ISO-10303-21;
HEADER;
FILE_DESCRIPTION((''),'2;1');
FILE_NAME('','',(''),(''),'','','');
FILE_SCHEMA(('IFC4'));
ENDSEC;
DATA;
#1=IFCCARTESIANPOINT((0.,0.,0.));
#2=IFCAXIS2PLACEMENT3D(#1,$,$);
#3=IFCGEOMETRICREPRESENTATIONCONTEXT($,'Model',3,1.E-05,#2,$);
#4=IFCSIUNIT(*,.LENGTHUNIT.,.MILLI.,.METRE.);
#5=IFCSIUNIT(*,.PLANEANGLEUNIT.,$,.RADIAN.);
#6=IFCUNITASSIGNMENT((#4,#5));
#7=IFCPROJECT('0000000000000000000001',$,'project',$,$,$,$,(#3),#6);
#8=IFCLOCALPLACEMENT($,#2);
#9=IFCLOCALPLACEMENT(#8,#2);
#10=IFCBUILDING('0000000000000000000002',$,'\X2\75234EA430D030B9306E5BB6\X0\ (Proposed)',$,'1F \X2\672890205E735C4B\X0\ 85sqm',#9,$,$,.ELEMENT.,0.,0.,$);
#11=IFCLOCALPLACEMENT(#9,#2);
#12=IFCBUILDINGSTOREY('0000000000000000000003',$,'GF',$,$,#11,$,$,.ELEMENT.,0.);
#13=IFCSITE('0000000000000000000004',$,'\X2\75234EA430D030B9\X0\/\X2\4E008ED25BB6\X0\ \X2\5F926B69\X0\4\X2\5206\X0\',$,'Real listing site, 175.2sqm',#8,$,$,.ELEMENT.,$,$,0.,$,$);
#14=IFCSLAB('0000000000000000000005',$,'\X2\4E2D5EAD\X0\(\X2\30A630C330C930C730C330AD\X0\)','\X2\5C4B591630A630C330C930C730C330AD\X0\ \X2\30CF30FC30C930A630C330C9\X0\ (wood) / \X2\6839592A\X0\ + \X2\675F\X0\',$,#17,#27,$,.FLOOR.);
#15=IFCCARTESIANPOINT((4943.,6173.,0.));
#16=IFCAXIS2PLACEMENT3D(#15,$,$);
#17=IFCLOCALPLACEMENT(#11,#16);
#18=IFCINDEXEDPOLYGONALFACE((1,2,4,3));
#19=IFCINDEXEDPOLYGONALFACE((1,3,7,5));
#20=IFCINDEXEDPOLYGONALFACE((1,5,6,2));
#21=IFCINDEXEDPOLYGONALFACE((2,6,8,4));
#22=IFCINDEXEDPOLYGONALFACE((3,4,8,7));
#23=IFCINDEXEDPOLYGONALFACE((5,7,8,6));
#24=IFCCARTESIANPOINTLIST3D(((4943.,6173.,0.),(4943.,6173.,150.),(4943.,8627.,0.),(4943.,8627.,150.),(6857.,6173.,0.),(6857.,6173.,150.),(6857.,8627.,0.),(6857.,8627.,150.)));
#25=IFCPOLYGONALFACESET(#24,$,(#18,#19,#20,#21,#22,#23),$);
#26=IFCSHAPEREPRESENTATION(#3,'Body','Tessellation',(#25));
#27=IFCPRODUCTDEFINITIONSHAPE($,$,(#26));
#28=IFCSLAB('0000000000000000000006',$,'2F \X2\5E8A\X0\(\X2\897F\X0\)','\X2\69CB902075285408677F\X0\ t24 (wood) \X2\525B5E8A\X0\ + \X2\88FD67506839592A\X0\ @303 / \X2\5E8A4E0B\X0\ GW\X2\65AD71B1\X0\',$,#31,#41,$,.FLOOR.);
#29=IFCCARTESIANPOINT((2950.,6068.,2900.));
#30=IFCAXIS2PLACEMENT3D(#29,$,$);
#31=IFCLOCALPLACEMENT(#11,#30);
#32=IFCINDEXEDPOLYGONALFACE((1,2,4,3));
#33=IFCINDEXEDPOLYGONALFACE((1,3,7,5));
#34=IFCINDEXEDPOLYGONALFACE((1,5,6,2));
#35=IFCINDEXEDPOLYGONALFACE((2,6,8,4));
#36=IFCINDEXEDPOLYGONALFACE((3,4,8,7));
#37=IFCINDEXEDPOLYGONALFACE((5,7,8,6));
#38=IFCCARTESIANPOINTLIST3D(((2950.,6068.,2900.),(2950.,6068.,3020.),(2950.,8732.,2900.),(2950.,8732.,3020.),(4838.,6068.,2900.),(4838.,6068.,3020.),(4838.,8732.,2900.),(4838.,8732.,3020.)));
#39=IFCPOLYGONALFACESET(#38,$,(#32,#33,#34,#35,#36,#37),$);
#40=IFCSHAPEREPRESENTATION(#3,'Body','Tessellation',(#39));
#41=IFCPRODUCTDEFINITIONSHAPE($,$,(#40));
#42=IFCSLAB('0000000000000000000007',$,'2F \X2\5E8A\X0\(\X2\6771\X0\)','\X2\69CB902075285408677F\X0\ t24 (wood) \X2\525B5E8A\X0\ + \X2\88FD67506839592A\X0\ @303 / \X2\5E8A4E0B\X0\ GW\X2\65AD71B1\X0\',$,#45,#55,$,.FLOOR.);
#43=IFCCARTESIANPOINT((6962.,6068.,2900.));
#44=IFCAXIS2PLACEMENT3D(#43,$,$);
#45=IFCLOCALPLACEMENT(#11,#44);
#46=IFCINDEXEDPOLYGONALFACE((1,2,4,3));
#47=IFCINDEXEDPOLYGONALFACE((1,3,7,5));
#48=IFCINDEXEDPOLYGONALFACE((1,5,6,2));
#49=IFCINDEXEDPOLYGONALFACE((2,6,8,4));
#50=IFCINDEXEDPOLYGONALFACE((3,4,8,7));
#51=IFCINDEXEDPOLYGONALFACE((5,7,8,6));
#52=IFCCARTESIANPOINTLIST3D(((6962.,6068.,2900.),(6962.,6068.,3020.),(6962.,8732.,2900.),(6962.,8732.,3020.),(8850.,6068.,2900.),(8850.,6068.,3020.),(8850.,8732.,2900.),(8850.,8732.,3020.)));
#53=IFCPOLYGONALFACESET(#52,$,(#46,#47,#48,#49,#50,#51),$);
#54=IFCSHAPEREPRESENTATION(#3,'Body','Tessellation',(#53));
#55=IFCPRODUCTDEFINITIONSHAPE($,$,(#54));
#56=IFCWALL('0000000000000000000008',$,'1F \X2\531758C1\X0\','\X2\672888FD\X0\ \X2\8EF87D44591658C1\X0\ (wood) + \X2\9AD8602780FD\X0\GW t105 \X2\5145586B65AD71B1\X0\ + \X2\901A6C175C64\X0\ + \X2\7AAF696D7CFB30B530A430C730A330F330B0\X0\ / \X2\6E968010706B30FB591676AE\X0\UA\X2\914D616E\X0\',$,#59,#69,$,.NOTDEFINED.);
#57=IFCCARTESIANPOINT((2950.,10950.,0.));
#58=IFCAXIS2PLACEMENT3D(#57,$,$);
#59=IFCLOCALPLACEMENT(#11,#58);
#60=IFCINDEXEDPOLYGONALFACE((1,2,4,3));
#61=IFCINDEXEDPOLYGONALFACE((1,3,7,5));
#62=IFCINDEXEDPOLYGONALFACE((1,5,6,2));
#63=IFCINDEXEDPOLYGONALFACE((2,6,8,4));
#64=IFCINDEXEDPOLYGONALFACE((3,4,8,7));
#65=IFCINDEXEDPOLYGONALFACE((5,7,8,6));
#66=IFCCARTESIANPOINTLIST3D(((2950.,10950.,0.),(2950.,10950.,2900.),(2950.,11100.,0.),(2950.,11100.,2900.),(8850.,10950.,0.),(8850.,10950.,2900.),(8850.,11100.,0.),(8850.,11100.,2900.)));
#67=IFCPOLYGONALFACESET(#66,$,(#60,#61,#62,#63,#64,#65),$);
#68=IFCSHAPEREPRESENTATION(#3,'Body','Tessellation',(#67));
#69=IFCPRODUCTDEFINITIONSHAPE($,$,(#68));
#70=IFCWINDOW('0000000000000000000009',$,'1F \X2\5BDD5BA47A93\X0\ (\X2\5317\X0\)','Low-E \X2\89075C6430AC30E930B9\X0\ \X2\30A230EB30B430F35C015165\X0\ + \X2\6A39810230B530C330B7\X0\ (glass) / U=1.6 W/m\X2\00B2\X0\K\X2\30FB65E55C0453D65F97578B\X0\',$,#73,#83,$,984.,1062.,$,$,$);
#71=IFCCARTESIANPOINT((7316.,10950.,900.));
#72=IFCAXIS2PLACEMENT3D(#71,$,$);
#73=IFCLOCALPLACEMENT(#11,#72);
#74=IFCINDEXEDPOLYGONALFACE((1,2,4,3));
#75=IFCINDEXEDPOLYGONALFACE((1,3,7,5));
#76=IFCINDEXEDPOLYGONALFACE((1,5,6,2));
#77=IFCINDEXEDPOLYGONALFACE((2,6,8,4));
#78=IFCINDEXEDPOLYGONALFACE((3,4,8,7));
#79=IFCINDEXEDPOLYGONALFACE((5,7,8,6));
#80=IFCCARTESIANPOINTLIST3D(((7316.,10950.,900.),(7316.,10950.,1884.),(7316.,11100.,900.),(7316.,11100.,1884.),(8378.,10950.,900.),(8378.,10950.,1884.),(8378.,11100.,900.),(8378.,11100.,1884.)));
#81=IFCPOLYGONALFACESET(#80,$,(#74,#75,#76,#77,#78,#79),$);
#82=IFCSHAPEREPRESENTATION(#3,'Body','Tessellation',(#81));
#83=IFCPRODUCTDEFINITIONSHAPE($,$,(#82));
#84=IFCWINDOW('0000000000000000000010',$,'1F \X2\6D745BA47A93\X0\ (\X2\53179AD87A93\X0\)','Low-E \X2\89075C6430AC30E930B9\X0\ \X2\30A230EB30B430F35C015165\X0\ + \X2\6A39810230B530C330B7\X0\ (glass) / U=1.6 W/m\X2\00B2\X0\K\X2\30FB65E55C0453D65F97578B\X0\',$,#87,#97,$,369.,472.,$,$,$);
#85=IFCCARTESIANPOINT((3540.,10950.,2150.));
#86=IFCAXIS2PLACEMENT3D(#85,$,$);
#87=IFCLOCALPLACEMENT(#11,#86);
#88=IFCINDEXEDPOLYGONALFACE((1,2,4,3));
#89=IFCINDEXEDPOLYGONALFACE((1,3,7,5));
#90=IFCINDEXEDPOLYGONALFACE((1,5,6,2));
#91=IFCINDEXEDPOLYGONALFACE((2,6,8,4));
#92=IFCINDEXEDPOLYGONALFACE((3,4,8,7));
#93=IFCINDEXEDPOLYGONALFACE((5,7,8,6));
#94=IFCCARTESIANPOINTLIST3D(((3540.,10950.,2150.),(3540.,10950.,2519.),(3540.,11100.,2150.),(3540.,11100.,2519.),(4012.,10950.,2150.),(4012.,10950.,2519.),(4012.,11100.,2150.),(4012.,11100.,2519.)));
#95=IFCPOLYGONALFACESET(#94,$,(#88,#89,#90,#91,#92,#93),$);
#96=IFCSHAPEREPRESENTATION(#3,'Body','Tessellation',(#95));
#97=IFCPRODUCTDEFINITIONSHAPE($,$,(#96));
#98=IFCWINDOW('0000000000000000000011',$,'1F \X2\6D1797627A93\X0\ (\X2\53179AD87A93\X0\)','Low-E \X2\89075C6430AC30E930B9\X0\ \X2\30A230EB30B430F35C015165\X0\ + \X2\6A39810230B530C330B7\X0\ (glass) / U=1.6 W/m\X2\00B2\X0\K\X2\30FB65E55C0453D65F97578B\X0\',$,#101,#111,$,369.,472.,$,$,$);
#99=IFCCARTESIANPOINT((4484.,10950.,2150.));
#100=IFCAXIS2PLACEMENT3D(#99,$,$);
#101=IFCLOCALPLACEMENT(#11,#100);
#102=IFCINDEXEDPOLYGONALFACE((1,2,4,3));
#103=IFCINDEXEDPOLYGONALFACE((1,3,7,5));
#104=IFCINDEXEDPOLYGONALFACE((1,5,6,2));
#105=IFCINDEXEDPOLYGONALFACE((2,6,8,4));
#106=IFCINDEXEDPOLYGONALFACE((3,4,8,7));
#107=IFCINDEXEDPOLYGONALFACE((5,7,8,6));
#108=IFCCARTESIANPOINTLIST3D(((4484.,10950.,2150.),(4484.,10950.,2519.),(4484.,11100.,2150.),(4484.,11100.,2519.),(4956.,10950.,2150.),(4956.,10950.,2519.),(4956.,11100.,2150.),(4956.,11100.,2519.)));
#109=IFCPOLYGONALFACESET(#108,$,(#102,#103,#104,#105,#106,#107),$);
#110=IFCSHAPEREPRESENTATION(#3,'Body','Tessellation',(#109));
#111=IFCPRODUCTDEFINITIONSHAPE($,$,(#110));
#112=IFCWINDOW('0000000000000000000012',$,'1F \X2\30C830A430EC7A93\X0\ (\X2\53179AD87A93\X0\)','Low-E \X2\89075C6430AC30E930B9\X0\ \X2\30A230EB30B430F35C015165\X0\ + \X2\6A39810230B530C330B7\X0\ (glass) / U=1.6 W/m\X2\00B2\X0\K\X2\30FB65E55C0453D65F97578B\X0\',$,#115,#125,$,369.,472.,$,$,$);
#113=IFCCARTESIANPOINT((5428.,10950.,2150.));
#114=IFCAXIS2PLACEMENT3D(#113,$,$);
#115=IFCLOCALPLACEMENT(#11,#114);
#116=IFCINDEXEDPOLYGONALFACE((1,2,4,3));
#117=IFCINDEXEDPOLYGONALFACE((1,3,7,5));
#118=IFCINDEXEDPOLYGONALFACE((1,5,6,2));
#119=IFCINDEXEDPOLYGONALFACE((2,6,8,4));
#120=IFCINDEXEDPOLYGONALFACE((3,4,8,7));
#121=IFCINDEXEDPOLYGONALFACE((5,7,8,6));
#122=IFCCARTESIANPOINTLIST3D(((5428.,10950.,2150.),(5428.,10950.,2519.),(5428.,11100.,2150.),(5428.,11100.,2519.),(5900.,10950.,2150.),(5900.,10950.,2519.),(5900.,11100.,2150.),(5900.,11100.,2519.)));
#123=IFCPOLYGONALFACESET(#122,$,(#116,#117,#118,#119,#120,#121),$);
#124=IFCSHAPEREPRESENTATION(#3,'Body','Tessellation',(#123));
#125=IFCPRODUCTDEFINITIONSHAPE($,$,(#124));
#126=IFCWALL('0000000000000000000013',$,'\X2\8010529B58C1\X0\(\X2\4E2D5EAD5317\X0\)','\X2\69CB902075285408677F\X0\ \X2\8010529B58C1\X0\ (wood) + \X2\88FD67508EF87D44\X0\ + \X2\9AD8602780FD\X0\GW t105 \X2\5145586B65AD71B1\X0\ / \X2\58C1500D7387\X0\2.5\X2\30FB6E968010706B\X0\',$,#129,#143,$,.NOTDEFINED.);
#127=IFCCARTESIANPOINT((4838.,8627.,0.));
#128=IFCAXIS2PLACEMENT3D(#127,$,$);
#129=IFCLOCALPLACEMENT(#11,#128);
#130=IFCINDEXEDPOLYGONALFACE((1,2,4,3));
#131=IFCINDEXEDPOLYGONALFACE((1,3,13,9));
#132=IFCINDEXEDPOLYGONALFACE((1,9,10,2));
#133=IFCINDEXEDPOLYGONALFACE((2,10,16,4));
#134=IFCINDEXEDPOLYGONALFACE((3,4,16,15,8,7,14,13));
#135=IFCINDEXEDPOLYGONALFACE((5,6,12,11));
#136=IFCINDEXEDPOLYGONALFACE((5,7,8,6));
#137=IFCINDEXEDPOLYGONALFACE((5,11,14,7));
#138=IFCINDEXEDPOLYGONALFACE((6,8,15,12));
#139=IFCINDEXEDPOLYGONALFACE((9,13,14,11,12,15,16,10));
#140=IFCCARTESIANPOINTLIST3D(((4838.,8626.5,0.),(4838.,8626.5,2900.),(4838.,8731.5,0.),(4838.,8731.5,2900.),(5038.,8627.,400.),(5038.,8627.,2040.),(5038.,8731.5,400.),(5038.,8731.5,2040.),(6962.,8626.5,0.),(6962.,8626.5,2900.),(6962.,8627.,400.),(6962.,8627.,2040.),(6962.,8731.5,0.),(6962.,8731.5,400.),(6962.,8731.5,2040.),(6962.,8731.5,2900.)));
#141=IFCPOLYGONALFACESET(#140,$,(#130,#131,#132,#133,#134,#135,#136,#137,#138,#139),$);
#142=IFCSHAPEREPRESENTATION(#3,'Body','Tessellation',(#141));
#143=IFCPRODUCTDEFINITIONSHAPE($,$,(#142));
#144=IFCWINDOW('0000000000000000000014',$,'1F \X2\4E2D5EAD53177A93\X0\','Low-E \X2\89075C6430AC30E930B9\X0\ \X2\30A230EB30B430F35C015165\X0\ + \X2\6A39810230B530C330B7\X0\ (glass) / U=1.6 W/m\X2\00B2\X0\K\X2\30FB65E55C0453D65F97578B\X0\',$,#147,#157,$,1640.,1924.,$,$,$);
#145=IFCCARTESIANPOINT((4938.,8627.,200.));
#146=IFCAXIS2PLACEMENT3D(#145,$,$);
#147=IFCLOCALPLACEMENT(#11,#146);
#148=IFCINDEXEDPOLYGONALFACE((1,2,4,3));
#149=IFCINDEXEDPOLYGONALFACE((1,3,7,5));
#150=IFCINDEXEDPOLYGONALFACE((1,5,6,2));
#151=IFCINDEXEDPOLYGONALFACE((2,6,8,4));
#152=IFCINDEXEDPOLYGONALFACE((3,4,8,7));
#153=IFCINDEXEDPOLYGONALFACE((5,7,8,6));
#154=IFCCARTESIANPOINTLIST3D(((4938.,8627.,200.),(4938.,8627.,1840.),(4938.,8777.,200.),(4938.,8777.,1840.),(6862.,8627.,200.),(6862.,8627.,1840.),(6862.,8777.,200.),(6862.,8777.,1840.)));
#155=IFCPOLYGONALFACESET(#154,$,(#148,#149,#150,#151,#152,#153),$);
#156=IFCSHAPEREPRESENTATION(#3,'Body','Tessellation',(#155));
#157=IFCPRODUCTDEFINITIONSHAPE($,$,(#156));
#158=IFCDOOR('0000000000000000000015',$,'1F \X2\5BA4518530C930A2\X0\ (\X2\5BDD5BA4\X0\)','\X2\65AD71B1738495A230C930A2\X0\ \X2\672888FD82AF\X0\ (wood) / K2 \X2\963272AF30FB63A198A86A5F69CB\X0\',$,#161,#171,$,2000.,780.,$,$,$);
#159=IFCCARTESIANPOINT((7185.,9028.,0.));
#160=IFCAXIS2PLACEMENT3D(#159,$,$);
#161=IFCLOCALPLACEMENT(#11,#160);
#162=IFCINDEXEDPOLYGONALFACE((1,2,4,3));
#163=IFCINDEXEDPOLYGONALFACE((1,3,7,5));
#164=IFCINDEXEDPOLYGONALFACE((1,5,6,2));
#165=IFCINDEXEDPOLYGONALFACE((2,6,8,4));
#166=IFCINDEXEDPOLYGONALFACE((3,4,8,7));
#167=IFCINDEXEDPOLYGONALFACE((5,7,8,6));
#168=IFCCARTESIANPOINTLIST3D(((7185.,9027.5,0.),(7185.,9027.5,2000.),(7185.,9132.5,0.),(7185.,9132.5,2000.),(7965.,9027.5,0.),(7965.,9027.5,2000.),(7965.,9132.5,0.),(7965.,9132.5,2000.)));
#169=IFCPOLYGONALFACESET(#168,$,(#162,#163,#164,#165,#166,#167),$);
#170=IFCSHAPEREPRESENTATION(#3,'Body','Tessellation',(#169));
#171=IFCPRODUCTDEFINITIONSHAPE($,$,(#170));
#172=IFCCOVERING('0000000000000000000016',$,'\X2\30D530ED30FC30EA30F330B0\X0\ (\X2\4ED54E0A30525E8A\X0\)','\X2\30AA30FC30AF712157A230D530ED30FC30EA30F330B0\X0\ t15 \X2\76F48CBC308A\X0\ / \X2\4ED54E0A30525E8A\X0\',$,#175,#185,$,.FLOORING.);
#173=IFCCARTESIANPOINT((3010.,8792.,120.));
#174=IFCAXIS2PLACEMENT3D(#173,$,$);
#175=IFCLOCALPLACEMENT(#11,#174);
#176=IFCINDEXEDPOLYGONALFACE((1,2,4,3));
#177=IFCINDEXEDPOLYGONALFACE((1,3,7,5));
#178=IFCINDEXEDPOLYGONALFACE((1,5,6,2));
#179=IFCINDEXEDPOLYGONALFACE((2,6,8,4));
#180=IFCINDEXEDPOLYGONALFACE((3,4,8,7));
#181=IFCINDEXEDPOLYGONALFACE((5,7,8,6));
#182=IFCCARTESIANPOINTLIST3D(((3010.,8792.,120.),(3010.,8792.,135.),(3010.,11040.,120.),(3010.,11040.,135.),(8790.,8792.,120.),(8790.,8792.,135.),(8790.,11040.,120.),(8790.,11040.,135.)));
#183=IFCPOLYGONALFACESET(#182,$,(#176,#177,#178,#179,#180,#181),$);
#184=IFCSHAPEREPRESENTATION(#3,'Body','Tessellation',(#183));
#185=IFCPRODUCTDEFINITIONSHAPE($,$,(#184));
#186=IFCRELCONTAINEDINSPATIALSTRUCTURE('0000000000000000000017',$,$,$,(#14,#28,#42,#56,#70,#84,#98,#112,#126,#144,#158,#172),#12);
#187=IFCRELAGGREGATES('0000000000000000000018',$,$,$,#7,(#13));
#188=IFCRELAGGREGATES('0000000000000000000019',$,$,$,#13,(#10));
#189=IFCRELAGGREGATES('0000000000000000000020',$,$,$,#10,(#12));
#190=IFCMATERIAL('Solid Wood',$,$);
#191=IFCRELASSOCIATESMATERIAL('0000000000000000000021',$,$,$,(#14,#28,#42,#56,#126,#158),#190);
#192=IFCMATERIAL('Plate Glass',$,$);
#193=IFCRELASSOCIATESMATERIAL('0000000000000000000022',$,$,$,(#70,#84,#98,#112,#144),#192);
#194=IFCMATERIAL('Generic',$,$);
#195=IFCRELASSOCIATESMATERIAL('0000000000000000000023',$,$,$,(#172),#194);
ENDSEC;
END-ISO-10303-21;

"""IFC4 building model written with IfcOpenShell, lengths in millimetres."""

from ifc_helpers import new_model, si_unit, frame, frame_2d, origin, place, context, project, spatial, rectangle, extrude, material, element, fill, save


model = new_model("IFC4")

# Units and contexts
model_context = context("Model", 3, precision=1e-05, world=origin())
ifc_project = project(units=[si_unit("LENGTHUNIT", "METRE", prefix="MILLI"), si_unit("PLANEANGLEUNIT", "RADIAN")], contexts=[model_context])

# Site, building, storey
site_placement = place(None, origin())
site = spatial("IfcSite", under=ifc_project, at=site_placement, Name="産交バス/一軒家 徒歩4分", ObjectType="Real listing site, 175.2sqm", CompositionType="ELEMENT", RefElevation=0.0)
building_placement = place(site_placement, origin())
building = spatial("IfcBuilding", under=site, at=building_placement, Name="産交バスの家 (Proposed)", ObjectType="1F 木造平屋 85sqm", CompositionType="ELEMENT", ElevationOfRefHeight=0.0, ElevationOfTerrain=0.0)
storey_placement = place(building_placement, origin())
storey = spatial("IfcBuildingStorey", under=building, at=storey_placement, Name="GF", CompositionType="ELEMENT", Elevation=0.0)

# Slabs
ifc_material_1 = material(Name="Solid Wood")
slab_1_placement = place(storey_placement, frame((4943.0, 6173.0, 0.0)))
element("IfcSlab", 1, at=slab_1_placement, inside=storey, material=ifc_material_1, Name="中庭(ウッドデッキ)", Description="屋外ウッドデッキ ハードウッド (wood) / 根太 + 束", PredefinedType="FLOOR", context=model_context, shape_type="SweptSolid", body=[
    extrude(rectangle(XDim=1914.0, YDim=2454.0, at=frame_2d((957.0, 1227.0))), frame((4943.0, 6173.0, 0.0)), (0.0, 0.0, 1.0), 150.0),
])
slab_2_placement = place(storey_placement, frame((2950.0, 6068.0, 2900.0)))
element("IfcSlab", 2, at=slab_2_placement, inside=storey, material=ifc_material_1, Name="2F 床(西)", Description="構造用合板 t24 (wood) 剛床 + 製材根太 @303 / 床下 GW断熱", PredefinedType="FLOOR", context=model_context, shape_type="SweptSolid", body=[
    extrude(rectangle(XDim=1888.0, YDim=2664.0, at=frame_2d((944.0, 1332.0))), frame((2950.0, 6068.0, 2900.0)), (0.0, 0.0, 1.0), 120.0),
])
slab_3_placement = place(storey_placement, frame((6962.0, 6068.0, 2900.0)))
element("IfcSlab", 3, at=slab_3_placement, inside=storey, material=ifc_material_1, Name="2F 床(東)", Description="構造用合板 t24 (wood) 剛床 + 製材根太 @303 / 床下 GW断熱", PredefinedType="FLOOR", context=model_context, shape_type="SweptSolid", body=[
    extrude(rectangle(XDim=1888.0, YDim=2664.0, at=frame_2d((944.0, 1332.0))), frame((6962.0, 6068.0, 2900.0)), (0.0, 0.0, 1.0), 120.0),
])

# Wall, openings, windows
wall_1_placement = place(storey_placement, frame((2950.0, 10950.0, 0.0)))
wall_1 = element("IfcWall", 4, at=wall_1_placement, inside=storey, material=ifc_material_1, Name="1F 北壁", Description="木製 軸組外壁 (wood) + 高性能GW t105 充填断熱 + 通気層 + 窯業系サイディング / 準耐火・外皮UA配慮", PredefinedType="NOTDEFINED", context=model_context, shape_type="SweptSolid", body=[
    extrude(rectangle(XDim=5900.0, YDim=150.0, at=frame_2d((2950.0, 75.0))), frame((2950.0, 10950.0, 0.0)), (0.0, 0.0, 1.0), 2900.0),
])
opening_1_placement = place(storey_placement, frame((7316.0, 10950.0, 900.0)))
opening_1 = element("IfcOpeningElement", 5, at=opening_1_placement, cuts=wall_1, PredefinedType="NOTDEFINED", context=model_context, shape_type="SweptSolid", body=[
    extrude(rectangle(XDim=1062.0, YDim=150.0, at=frame_2d((531.0, 75.0))), frame((7316.0, 10950.0, 900.0)), (0.0, 0.0, 1.0), 984.0),
])
opening_2_placement = place(storey_placement, frame((3540.0, 10950.0, 2150.0)))
opening_2 = element("IfcOpeningElement", 6, at=opening_2_placement, cuts=wall_1, PredefinedType="NOTDEFINED", context=model_context, shape_type="SweptSolid", body=[
    extrude(rectangle(XDim=472.0, YDim=150.0, at=frame_2d((236.0, 75.0))), frame((3540.0, 10950.0, 2150.0)), (0.0, 0.0, 1.0), 369.0),
])
opening_3_placement = place(storey_placement, frame((4484.0, 10950.0, 2150.0)))
opening_3 = element("IfcOpeningElement", 7, at=opening_3_placement, cuts=wall_1, PredefinedType="NOTDEFINED", context=model_context, shape_type="SweptSolid", body=[
    extrude(rectangle(XDim=472.0, YDim=150.0, at=frame_2d((236.0, 75.0))), frame((4484.0, 10950.0, 2150.0)), (0.0, 0.0, 1.0), 369.0),
])
opening_4_placement = place(storey_placement, frame((5428.0, 10950.0, 2150.0)))
opening_4 = element("IfcOpeningElement", 8, at=opening_4_placement, cuts=wall_1, PredefinedType="NOTDEFINED", context=model_context, shape_type="SweptSolid", body=[
    extrude(rectangle(XDim=472.0, YDim=150.0, at=frame_2d((236.0, 75.0))), frame((5428.0, 10950.0, 2150.0)), (0.0, 0.0, 1.0), 369.0),
])
ifc_material_2 = material(Name="Plate Glass")
window_1_placement = place(storey_placement, frame((7316.0, 10950.0, 900.0)))
window_1 = element("IfcWindow", 9, at=window_1_placement, inside=storey, material=ifc_material_2, Name="1F 寝室窓 (北)", Description="Low-E 複層ガラス アルゴン封入 + 樹脂サッシ (glass) / U=1.6 W/m²K・日射取得型", OverallHeight=984.0, OverallWidth=1062.0, context=model_context, shape_type="SweptSolid", body=[
    extrude(rectangle(XDim=1062.0, YDim=150.0, at=frame_2d((531.0, 75.0))), frame((7316.0, 10950.0, 900.0)), (0.0, 0.0, 1.0), 984.0),
])
fill(opening_1, window_1)
window_2_placement = place(storey_placement, frame((3540.0, 10950.0, 2150.0)))
window_2 = element("IfcWindow", 10, at=window_2_placement, inside=storey, material=ifc_material_2, Name="1F 浴室窓 (北高窓)", Description="Low-E 複層ガラス アルゴン封入 + 樹脂サッシ (glass) / U=1.6 W/m²K・日射取得型", OverallHeight=369.0, OverallWidth=472.0, context=model_context, shape_type="SweptSolid", body=[
    extrude(rectangle(XDim=472.0, YDim=150.0, at=frame_2d((236.0, 75.0))), frame((3540.0, 10950.0, 2150.0)), (0.0, 0.0, 1.0), 369.0),
])
fill(opening_2, window_2)
window_3_placement = place(storey_placement, frame((4484.0, 10950.0, 2150.0)))
window_3 = element("IfcWindow", 11, at=window_3_placement, inside=storey, material=ifc_material_2, Name="1F 洗面窓 (北高窓)", Description="Low-E 複層ガラス アルゴン封入 + 樹脂サッシ (glass) / U=1.6 W/m²K・日射取得型", OverallHeight=369.0, OverallWidth=472.0, context=model_context, shape_type="SweptSolid", body=[
    extrude(rectangle(XDim=472.0, YDim=150.0, at=frame_2d((236.0, 75.0))), frame((4484.0, 10950.0, 2150.0)), (0.0, 0.0, 1.0), 369.0),
])
fill(opening_3, window_3)
window_4_placement = place(storey_placement, frame((5428.0, 10950.0, 2150.0)))
window_4 = element("IfcWindow", 12, at=window_4_placement, inside=storey, material=ifc_material_2, Name="1F トイレ窓 (北高窓)", Description="Low-E 複層ガラス アルゴン封入 + 樹脂サッシ (glass) / U=1.6 W/m²K・日射取得型", OverallHeight=369.0, OverallWidth=472.0, context=model_context, shape_type="SweptSolid", body=[
    extrude(rectangle(XDim=472.0, YDim=150.0, at=frame_2d((236.0, 75.0))), frame((5428.0, 10950.0, 2150.0)), (0.0, 0.0, 1.0), 369.0),
])
fill(opening_4, window_4)

# Wall, opening, window
wall_2_placement = place(storey_placement, frame((4838.0, 8627.0, 0.0)))
wall_2 = element("IfcWall", 13, at=wall_2_placement, inside=storey, material=ifc_material_1, Name="耐力壁(中庭北)", Description="構造用合板 耐力壁 (wood) + 製材軸組 + 高性能GW t105 充填断熱 / 壁倍率2.5・準耐火", PredefinedType="NOTDEFINED", context=model_context, shape_type="SweptSolid", body=[
    extrude(rectangle(XDim=2124.0, YDim=105.0, at=frame_2d((1062.0, 52.0))), frame((4838.0, 8627.0, 0.0)), (0.0, 0.0, 1.0), 2900.0),
])
opening_5_placement = place(storey_placement, frame((4938.0, 8627.0, 200.0)))
opening_5 = element("IfcOpeningElement", 14, at=opening_5_placement, cuts=wall_2, PredefinedType="NOTDEFINED", context=model_context, shape_type="SweptSolid", body=[
    extrude(rectangle(XDim=1924.0, YDim=150.0, at=frame_2d((962.0, 75.0))), frame((4938.0, 8627.0, 200.0)), (0.0, 0.0, 1.0), 1640.0),
])
window_5_placement = place(storey_placement, frame((4938.0, 8627.0, 200.0)))
window_5 = element("IfcWindow", 15, at=window_5_placement, inside=storey, material=ifc_material_2, Name="1F 中庭北窓", Description="Low-E 複層ガラス アルゴン封入 + 樹脂サッシ (glass) / U=1.6 W/m²K・日射取得型", OverallHeight=1640.0, OverallWidth=1924.0, context=model_context, shape_type="SweptSolid", body=[
    extrude(rectangle(XDim=1924.0, YDim=150.0, at=frame_2d((962.0, 75.0))), frame((4938.0, 8627.0, 200.0)), (0.0, 0.0, 1.0), 1640.0),
])
fill(opening_5, window_5)

# Door
door_1_placement = place(storey_placement, frame((7185.0, 9028.0, 0.0)))
element("IfcDoor", 16, at=door_1_placement, inside=storey, material=ifc_material_1, Name="1F 室内ドア (寝室)", Description="断熱玄関ドア 木製芯 (wood) / K2 防犯・採風機構", OverallHeight=2000.0, OverallWidth=780.0, context=model_context, shape_type="SweptSolid", body=[
    extrude(rectangle(XDim=780.0, YDim=105.0, at=frame_2d((390.0, 52.0))), frame((7185.0, 9028.0, 0.0)), (0.0, 0.0, 1.0), 2000.0),
])

# Covering
ifc_material_3 = material(Name="Generic")
covering_1_placement = place(storey_placement, frame((3010.0, 8792.0, 120.0)))
element("IfcCovering", 17, at=covering_1_placement, inside=storey, material=ifc_material_3, Name="フローリング (仕上げ床)", Description="オーク無垢フローリング t15 直貼り / 仕上げ床", PredefinedType="FLOORING", context=model_context, shape_type="SweptSolid", body=[
    extrude(rectangle(XDim=5780.0, YDim=2248.0, at=frame_2d((2890.0, 1124.0))), frame((3010.0, 8792.0, 120.0)), (0.0, 0.0, 1.0), 15.0),
])

save(model, "model.ifc")
